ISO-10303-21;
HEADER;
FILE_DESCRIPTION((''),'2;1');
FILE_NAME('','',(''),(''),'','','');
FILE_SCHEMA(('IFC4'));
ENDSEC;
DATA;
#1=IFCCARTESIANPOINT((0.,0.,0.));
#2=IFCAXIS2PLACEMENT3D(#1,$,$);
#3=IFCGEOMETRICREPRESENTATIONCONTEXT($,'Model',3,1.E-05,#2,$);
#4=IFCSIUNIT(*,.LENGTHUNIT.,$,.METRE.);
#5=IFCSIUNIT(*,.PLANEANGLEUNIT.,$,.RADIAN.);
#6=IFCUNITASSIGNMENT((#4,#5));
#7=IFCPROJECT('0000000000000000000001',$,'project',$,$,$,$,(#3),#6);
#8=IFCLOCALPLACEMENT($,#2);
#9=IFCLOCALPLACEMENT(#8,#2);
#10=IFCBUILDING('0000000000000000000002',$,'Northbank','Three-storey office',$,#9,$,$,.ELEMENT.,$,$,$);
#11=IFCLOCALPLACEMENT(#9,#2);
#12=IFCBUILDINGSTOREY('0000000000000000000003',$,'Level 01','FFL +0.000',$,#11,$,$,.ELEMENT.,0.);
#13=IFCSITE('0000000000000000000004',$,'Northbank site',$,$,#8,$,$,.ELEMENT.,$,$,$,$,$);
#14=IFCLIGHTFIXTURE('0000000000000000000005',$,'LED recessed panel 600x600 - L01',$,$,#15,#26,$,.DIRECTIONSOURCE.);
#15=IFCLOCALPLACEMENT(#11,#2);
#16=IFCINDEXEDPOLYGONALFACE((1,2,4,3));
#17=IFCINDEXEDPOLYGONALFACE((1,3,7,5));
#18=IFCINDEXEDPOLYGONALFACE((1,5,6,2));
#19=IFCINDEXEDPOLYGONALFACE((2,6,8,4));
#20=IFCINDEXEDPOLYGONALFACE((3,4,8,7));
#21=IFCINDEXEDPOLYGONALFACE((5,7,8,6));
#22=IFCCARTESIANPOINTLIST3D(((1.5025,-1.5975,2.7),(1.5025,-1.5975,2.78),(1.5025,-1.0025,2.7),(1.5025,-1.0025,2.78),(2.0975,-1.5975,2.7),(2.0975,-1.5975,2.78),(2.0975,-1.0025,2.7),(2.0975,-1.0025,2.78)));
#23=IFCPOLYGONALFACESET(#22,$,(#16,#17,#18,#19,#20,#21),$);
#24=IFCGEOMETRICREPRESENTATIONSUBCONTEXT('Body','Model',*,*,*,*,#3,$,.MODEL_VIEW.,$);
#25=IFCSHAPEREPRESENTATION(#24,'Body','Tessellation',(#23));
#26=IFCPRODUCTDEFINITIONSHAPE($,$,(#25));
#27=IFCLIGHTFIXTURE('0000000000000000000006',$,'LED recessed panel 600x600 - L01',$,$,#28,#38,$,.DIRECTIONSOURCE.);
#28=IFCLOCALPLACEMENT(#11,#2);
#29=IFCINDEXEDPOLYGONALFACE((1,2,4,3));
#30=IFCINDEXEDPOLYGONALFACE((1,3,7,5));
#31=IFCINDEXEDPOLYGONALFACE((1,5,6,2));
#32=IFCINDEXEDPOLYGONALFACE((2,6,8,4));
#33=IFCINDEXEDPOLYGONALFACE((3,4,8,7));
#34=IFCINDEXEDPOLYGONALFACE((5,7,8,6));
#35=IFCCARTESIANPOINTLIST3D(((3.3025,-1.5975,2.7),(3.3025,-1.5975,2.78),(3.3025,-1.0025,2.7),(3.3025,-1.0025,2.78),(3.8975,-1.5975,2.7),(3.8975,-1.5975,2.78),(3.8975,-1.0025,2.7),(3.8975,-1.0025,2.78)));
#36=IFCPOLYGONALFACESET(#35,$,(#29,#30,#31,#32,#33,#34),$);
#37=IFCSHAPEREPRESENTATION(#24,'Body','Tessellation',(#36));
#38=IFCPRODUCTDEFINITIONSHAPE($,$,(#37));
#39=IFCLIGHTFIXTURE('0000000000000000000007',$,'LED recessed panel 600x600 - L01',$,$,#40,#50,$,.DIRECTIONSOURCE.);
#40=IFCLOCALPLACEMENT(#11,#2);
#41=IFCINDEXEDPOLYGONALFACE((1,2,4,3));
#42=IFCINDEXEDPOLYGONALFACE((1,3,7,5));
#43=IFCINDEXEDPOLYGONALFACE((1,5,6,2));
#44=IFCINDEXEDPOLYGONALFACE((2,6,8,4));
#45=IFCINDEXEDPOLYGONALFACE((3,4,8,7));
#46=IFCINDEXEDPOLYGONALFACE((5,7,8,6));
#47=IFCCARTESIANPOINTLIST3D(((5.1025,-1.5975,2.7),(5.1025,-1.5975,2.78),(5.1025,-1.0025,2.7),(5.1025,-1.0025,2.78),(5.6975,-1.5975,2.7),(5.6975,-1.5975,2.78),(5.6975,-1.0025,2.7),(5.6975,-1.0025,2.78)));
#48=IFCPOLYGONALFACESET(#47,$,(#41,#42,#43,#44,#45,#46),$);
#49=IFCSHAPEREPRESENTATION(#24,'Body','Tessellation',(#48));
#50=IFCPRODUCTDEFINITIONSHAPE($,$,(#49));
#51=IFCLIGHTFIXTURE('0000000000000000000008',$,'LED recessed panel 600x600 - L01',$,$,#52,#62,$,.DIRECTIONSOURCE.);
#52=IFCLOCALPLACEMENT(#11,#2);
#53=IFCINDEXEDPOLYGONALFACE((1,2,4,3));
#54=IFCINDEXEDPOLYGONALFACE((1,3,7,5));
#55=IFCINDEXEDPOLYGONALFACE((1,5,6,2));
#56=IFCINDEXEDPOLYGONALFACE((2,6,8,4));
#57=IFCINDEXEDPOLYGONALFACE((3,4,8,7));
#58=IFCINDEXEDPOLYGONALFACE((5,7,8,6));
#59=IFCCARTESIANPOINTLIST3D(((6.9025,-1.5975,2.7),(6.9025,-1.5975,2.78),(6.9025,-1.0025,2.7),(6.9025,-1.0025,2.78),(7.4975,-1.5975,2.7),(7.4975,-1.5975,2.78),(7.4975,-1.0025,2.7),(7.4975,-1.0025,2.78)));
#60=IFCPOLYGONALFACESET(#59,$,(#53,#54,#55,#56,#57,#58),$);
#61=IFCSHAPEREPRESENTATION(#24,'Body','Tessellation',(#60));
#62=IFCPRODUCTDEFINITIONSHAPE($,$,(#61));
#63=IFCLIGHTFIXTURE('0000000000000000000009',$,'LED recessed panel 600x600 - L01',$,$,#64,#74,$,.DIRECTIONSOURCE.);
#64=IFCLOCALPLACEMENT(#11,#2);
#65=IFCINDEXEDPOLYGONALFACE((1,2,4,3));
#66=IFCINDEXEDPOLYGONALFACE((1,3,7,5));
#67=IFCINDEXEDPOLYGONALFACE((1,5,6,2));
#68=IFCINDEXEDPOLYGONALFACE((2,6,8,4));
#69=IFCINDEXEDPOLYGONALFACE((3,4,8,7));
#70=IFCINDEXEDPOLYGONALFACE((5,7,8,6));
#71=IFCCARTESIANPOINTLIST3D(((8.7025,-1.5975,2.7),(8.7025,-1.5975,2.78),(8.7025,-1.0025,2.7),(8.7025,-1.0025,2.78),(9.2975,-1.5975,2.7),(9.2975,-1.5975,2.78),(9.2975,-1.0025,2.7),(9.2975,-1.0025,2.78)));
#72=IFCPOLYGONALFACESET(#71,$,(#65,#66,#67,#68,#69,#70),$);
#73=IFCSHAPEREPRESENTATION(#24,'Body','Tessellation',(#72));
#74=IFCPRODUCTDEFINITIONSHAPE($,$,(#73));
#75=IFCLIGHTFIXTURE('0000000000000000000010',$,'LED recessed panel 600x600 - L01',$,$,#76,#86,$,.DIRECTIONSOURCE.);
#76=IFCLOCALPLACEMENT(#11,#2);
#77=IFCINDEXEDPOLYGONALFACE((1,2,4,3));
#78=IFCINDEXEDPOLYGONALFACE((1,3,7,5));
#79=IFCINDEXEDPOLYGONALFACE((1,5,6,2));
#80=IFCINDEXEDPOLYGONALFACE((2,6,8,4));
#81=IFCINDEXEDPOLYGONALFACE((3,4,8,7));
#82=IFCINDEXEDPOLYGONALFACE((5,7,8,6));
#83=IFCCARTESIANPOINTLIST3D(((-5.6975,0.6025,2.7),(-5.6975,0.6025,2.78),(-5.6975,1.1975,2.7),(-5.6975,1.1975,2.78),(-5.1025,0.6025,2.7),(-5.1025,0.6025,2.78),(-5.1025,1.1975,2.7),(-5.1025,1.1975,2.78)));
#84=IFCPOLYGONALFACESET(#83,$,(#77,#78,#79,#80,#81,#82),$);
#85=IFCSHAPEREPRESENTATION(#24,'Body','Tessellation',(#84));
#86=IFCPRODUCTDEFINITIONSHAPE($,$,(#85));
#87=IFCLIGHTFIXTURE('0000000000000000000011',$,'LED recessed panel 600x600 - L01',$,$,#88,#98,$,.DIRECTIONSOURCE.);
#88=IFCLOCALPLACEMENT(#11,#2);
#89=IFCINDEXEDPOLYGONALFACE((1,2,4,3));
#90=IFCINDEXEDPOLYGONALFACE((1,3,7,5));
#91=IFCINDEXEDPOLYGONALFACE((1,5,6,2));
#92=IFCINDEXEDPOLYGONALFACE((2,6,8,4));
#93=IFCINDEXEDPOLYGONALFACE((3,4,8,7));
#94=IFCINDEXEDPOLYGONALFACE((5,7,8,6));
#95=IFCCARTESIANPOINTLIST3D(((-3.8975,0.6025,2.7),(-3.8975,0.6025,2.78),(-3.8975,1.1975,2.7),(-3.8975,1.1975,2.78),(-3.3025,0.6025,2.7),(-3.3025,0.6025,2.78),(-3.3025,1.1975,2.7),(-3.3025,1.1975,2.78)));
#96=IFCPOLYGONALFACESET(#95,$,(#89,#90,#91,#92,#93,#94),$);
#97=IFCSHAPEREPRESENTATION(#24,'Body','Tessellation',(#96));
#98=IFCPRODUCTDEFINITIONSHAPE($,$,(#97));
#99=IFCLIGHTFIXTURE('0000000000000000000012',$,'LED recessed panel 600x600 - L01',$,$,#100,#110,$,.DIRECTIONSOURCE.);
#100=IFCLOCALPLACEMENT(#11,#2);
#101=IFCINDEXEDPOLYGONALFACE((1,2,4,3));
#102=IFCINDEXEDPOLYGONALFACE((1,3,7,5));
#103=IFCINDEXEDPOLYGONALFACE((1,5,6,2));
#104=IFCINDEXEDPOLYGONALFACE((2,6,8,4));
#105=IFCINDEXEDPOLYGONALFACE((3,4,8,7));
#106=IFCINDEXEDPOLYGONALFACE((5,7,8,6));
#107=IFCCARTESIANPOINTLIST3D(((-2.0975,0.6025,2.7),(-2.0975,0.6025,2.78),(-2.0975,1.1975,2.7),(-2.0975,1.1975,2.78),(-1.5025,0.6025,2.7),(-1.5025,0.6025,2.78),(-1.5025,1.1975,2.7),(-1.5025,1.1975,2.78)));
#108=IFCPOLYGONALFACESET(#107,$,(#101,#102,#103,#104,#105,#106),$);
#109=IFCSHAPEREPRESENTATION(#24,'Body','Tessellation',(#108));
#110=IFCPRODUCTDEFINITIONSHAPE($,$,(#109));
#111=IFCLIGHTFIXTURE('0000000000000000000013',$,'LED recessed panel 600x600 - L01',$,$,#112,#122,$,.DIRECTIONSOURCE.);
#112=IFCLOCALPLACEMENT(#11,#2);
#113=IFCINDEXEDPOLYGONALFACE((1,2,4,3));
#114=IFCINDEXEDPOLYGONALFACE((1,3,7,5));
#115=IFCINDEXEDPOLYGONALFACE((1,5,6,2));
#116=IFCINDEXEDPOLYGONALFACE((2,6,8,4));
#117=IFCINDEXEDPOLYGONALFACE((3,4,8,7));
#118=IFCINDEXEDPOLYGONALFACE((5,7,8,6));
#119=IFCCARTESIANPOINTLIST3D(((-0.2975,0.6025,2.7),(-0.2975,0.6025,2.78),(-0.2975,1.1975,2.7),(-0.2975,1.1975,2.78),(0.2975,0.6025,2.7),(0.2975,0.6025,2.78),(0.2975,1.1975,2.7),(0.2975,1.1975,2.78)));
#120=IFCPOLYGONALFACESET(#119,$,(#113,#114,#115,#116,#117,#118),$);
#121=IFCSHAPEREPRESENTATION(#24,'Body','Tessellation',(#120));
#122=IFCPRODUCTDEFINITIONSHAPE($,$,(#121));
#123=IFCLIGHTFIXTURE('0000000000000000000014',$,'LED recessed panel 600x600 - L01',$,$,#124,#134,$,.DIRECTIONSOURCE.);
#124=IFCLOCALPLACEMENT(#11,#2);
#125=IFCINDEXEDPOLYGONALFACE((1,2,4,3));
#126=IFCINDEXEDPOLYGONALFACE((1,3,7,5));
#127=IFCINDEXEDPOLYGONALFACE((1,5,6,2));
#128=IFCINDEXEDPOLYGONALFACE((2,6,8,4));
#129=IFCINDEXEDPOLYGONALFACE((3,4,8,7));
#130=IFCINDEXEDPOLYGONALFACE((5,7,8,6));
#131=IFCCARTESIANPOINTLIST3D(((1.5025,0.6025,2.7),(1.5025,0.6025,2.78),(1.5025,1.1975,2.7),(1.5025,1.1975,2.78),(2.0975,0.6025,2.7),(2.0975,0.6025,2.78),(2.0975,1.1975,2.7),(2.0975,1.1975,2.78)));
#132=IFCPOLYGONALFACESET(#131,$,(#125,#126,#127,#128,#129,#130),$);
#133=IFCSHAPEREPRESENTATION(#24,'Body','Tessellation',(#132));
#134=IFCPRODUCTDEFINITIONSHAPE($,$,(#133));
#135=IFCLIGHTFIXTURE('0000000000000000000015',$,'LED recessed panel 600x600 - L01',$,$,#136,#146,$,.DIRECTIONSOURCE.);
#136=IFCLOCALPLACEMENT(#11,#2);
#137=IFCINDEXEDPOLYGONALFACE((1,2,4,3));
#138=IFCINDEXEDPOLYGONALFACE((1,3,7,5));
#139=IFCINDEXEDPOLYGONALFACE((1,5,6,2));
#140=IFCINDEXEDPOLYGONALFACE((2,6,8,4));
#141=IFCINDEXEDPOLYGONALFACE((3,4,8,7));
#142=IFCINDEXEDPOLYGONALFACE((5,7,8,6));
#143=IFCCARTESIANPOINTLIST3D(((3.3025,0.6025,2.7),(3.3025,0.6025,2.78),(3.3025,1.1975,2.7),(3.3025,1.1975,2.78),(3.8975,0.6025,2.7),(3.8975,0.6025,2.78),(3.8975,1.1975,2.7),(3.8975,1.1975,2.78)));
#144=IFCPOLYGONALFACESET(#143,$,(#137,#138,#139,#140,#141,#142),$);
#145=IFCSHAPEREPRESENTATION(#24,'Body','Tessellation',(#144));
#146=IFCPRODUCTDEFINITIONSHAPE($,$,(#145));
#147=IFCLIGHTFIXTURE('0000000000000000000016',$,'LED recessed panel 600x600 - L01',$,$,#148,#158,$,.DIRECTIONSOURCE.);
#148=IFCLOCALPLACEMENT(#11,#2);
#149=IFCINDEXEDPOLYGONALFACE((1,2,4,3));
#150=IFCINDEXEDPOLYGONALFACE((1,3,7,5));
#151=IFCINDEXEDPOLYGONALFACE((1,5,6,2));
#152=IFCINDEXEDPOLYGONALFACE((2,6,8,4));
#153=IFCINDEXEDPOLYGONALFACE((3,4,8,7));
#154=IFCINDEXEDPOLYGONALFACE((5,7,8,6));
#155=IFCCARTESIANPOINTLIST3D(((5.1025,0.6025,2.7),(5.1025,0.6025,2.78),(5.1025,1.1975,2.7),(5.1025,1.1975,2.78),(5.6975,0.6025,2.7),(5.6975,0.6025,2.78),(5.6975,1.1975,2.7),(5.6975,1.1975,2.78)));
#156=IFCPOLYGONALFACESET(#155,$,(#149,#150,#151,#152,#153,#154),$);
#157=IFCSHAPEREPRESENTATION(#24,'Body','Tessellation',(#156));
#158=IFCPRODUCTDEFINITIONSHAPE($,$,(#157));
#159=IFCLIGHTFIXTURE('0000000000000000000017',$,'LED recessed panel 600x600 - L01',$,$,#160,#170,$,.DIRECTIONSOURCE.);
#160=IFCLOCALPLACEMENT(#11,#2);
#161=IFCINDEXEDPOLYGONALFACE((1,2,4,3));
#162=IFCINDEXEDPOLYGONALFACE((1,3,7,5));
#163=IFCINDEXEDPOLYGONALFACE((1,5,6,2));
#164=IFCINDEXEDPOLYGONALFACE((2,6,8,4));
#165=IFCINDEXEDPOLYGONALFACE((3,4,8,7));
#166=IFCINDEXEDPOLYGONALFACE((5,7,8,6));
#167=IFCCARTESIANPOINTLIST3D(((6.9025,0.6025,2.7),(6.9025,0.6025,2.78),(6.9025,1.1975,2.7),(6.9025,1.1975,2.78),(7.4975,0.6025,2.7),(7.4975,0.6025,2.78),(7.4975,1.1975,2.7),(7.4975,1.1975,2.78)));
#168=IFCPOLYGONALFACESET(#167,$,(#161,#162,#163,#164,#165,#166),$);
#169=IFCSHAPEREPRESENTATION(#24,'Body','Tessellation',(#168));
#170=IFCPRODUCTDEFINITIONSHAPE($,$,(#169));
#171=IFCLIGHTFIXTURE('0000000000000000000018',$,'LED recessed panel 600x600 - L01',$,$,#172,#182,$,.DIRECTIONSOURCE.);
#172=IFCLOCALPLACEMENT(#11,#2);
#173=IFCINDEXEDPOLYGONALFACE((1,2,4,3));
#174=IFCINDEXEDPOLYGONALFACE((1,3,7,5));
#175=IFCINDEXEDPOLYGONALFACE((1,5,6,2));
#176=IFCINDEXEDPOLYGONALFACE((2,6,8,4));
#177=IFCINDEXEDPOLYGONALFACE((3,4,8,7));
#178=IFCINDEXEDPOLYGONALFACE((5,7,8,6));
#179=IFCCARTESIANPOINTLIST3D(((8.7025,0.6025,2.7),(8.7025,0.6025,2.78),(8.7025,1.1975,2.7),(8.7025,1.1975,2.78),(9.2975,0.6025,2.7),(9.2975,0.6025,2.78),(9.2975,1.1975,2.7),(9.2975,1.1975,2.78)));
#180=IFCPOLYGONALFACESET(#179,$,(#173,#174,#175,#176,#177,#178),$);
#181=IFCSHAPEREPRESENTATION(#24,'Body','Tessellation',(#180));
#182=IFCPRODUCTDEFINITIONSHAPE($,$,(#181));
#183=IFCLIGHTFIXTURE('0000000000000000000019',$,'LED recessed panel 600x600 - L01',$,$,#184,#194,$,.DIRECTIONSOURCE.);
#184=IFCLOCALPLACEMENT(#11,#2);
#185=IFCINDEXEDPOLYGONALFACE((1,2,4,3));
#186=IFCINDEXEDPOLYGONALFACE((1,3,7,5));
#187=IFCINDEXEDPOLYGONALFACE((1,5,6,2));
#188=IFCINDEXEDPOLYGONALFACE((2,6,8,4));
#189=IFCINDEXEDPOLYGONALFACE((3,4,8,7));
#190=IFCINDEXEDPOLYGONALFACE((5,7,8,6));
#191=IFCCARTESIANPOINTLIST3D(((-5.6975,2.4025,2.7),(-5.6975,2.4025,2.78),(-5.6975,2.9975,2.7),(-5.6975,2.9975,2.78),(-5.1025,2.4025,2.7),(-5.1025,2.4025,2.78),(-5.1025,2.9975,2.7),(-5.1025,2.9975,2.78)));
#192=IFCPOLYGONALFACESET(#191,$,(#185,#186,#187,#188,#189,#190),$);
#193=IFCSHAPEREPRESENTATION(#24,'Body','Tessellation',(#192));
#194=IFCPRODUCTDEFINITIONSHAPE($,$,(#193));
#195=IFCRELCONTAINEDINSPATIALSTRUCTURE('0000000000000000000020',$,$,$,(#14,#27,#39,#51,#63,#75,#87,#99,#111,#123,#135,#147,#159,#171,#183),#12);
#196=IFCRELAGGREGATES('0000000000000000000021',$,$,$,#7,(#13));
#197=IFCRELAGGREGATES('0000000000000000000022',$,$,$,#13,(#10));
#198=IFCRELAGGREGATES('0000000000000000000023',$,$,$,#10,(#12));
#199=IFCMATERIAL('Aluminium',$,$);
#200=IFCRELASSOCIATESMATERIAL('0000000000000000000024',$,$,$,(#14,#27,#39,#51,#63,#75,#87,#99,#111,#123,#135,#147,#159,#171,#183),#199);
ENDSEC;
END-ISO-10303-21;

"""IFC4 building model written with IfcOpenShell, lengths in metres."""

from ifc_helpers import new_model, si_unit, frame, origin, place, context, subcontext, project, spatial, rectangle, extrude, material, element, save


model = new_model("IFC4")

# Units and contexts
model_context = context("Model", 3, precision=1e-05, world=origin())
body_context = subcontext(model_context, "Body", "Model", "MODEL_VIEW")
ifc_project = project(units=[si_unit("LENGTHUNIT", "METRE"), si_unit("PLANEANGLEUNIT", "RADIAN")], contexts=[model_context])

# Site, building, storey
site_placement = place(None, origin())
site = spatial("IfcSite", under=ifc_project, at=site_placement, Name="Northbank site", CompositionType="ELEMENT")
building_placement = place(site_placement, origin())
building = spatial("IfcBuilding", under=site, at=building_placement, Name="Northbank", Description="Three-storey office", CompositionType="ELEMENT")
storey_placement = place(building_placement, origin())
storey = spatial("IfcBuildingStorey", under=building, at=storey_placement, Name="Level 01", Description="FFL +0.000", CompositionType="ELEMENT", Elevation=0.0)

# Light fixtures
ifc_material = material(Name="Aluminium")
light_fixture_1_placement = place(storey_placement, origin())
element("IfcLightFixture", 1, at=light_fixture_1_placement, inside=storey, material=ifc_material, Name="LED recessed panel 600x600 - L01", PredefinedType="DIRECTIONSOURCE", context=body_context, shape_type="SweptSolid", body=[
    extrude(rectangle(XDim=0.595, YDim=0.595), frame((1.8, -1.3, 2.7)), (0.0, 0.0, 1.0), 0.08),
])
light_fixture_2_placement = place(storey_placement, origin())
element("IfcLightFixture", 2, at=light_fixture_2_placement, inside=storey, material=ifc_material, Name="LED recessed panel 600x600 - L01", PredefinedType="DIRECTIONSOURCE", context=body_context, shape_type="SweptSolid", body=[
    extrude(rectangle(XDim=0.595, YDim=0.595), frame((3.6, -1.3, 2.7)), (0.0, 0.0, 1.0), 0.08),
])
light_fixture_3_placement = place(storey_placement, origin())
element("IfcLightFixture", 3, at=light_fixture_3_placement, inside=storey, material=ifc_material, Name="LED recessed panel 600x600 - L01", PredefinedType="DIRECTIONSOURCE", context=body_context, shape_type="SweptSolid", body=[
    extrude(rectangle(XDim=0.595, YDim=0.595), frame((5.4, -1.3, 2.7)), (0.0, 0.0, 1.0), 0.08),
])
light_fixture_4_placement = place(storey_placement, origin())
element("IfcLightFixture", 4, at=light_fixture_4_placement, inside=storey, material=ifc_material, Name="LED recessed panel 600x600 - L01", PredefinedType="DIRECTIONSOURCE", context=body_context, shape_type="SweptSolid", body=[
    extrude(rectangle(XDim=0.595, YDim=0.595), frame((7.2, -1.3, 2.7)), (0.0, 0.0, 1.0), 0.08),
])
light_fixture_5_placement = place(storey_placement, origin())
element("IfcLightFixture", 5, at=light_fixture_5_placement, inside=storey, material=ifc_material, Name="LED recessed panel 600x600 - L01", PredefinedType="DIRECTIONSOURCE", context=body_context, shape_type="SweptSolid", body=[
    extrude(rectangle(XDim=0.595, YDim=0.595), frame((9.0, -1.3, 2.7)), (0.0, 0.0, 1.0), 0.08),
])
light_fixture_6_placement = place(storey_placement, origin())
element("IfcLightFixture", 6, at=light_fixture_6_placement, inside=storey, material=ifc_material, Name="LED recessed panel 600x600 - L01", PredefinedType="DIRECTIONSOURCE", context=body_context, shape_type="SweptSolid", body=[
    extrude(rectangle(XDim=0.595, YDim=0.595), frame((-5.4, 0.9, 2.7)), (0.0, 0.0, 1.0), 0.08),
])
light_fixture_7_placement = place(storey_placement, origin())
element("IfcLightFixture", 7, at=light_fixture_7_placement, inside=storey, material=ifc_material, Name="LED recessed panel 600x600 - L01", PredefinedType="DIRECTIONSOURCE", context=body_context, shape_type="SweptSolid", body=[
    extrude(rectangle(XDim=0.595, YDim=0.595), frame((-3.6, 0.9, 2.7)), (0.0, 0.0, 1.0), 0.08),
])
light_fixture_8_placement = place(storey_placement, origin())
element("IfcLightFixture", 8, at=light_fixture_8_placement, inside=storey, material=ifc_material, Name="LED recessed panel 600x600 - L01", PredefinedType="DIRECTIONSOURCE", context=body_context, shape_type="SweptSolid", body=[
    extrude(rectangle(XDim=0.595, YDim=0.595), frame((-1.8, 0.9, 2.7)), (0.0, 0.0, 1.0), 0.08),
])
light_fixture_9_placement = place(storey_placement, origin())
element("IfcLightFixture", 9, at=light_fixture_9_placement, inside=storey, material=ifc_material, Name="LED recessed panel 600x600 - L01", PredefinedType="DIRECTIONSOURCE", context=body_context, shape_type="SweptSolid", body=[
    extrude(rectangle(XDim=0.595, YDim=0.595), frame((0.0, 0.9, 2.7)), (0.0, 0.0, 1.0), 0.08),
])
light_fixture_10_placement = place(storey_placement, origin())
element("IfcLightFixture", 10, at=light_fixture_10_placement, inside=storey, material=ifc_material, Name="LED recessed panel 600x600 - L01", PredefinedType="DIRECTIONSOURCE", context=body_context, shape_type="SweptSolid", body=[
    extrude(rectangle(XDim=0.595, YDim=0.595), frame((1.8, 0.9, 2.7)), (0.0, 0.0, 1.0), 0.08),
])
light_fixture_11_placement = place(storey_placement, origin())
element("IfcLightFixture", 11, at=light_fixture_11_placement, inside=storey, material=ifc_material, Name="LED recessed panel 600x600 - L01", PredefinedType="DIRECTIONSOURCE", context=body_context, shape_type="SweptSolid", body=[
    extrude(rectangle(XDim=0.595, YDim=0.595), frame((3.6, 0.9, 2.7)), (0.0, 0.0, 1.0), 0.08),
])
light_fixture_12_placement = place(storey_placement, origin())
element("IfcLightFixture", 12, at=light_fixture_12_placement, inside=storey, material=ifc_material, Name="LED recessed panel 600x600 - L01", PredefinedType="DIRECTIONSOURCE", context=body_context, shape_type="SweptSolid", body=[
    extrude(rectangle(XDim=0.595, YDim=0.595), frame((5.4, 0.9, 2.7)), (0.0, 0.0, 1.0), 0.08),
])
light_fixture_13_placement = place(storey_placement, origin())
element("IfcLightFixture", 13, at=light_fixture_13_placement, inside=storey, material=ifc_material, Name="LED recessed panel 600x600 - L01", PredefinedType="DIRECTIONSOURCE", context=body_context, shape_type="SweptSolid", body=[
    extrude(rectangle(XDim=0.595, YDim=0.595), frame((7.2, 0.9, 2.7)), (0.0, 0.0, 1.0), 0.08),
])
light_fixture_14_placement = place(storey_placement, origin())
element("IfcLightFixture", 14, at=light_fixture_14_placement, inside=storey, material=ifc_material, Name="LED recessed panel 600x600 - L01", PredefinedType="DIRECTIONSOURCE", context=body_context, shape_type="SweptSolid", body=[
    extrude(rectangle(XDim=0.595, YDim=0.595), frame((9.0, 0.9, 2.7)), (0.0, 0.0, 1.0), 0.08),
])
light_fixture_15_placement = place(storey_placement, origin())
element("IfcLightFixture", 15, at=light_fixture_15_placement, inside=storey, material=ifc_material, Name="LED recessed panel 600x600 - L01", PredefinedType="DIRECTIONSOURCE", context=body_context, shape_type="SweptSolid", body=[
    extrude(rectangle(XDim=0.595, YDim=0.595), frame((-5.4, 2.7, 2.7)), (0.0, 0.0, 1.0), 0.08),
])

save(model, "model.ifc")
